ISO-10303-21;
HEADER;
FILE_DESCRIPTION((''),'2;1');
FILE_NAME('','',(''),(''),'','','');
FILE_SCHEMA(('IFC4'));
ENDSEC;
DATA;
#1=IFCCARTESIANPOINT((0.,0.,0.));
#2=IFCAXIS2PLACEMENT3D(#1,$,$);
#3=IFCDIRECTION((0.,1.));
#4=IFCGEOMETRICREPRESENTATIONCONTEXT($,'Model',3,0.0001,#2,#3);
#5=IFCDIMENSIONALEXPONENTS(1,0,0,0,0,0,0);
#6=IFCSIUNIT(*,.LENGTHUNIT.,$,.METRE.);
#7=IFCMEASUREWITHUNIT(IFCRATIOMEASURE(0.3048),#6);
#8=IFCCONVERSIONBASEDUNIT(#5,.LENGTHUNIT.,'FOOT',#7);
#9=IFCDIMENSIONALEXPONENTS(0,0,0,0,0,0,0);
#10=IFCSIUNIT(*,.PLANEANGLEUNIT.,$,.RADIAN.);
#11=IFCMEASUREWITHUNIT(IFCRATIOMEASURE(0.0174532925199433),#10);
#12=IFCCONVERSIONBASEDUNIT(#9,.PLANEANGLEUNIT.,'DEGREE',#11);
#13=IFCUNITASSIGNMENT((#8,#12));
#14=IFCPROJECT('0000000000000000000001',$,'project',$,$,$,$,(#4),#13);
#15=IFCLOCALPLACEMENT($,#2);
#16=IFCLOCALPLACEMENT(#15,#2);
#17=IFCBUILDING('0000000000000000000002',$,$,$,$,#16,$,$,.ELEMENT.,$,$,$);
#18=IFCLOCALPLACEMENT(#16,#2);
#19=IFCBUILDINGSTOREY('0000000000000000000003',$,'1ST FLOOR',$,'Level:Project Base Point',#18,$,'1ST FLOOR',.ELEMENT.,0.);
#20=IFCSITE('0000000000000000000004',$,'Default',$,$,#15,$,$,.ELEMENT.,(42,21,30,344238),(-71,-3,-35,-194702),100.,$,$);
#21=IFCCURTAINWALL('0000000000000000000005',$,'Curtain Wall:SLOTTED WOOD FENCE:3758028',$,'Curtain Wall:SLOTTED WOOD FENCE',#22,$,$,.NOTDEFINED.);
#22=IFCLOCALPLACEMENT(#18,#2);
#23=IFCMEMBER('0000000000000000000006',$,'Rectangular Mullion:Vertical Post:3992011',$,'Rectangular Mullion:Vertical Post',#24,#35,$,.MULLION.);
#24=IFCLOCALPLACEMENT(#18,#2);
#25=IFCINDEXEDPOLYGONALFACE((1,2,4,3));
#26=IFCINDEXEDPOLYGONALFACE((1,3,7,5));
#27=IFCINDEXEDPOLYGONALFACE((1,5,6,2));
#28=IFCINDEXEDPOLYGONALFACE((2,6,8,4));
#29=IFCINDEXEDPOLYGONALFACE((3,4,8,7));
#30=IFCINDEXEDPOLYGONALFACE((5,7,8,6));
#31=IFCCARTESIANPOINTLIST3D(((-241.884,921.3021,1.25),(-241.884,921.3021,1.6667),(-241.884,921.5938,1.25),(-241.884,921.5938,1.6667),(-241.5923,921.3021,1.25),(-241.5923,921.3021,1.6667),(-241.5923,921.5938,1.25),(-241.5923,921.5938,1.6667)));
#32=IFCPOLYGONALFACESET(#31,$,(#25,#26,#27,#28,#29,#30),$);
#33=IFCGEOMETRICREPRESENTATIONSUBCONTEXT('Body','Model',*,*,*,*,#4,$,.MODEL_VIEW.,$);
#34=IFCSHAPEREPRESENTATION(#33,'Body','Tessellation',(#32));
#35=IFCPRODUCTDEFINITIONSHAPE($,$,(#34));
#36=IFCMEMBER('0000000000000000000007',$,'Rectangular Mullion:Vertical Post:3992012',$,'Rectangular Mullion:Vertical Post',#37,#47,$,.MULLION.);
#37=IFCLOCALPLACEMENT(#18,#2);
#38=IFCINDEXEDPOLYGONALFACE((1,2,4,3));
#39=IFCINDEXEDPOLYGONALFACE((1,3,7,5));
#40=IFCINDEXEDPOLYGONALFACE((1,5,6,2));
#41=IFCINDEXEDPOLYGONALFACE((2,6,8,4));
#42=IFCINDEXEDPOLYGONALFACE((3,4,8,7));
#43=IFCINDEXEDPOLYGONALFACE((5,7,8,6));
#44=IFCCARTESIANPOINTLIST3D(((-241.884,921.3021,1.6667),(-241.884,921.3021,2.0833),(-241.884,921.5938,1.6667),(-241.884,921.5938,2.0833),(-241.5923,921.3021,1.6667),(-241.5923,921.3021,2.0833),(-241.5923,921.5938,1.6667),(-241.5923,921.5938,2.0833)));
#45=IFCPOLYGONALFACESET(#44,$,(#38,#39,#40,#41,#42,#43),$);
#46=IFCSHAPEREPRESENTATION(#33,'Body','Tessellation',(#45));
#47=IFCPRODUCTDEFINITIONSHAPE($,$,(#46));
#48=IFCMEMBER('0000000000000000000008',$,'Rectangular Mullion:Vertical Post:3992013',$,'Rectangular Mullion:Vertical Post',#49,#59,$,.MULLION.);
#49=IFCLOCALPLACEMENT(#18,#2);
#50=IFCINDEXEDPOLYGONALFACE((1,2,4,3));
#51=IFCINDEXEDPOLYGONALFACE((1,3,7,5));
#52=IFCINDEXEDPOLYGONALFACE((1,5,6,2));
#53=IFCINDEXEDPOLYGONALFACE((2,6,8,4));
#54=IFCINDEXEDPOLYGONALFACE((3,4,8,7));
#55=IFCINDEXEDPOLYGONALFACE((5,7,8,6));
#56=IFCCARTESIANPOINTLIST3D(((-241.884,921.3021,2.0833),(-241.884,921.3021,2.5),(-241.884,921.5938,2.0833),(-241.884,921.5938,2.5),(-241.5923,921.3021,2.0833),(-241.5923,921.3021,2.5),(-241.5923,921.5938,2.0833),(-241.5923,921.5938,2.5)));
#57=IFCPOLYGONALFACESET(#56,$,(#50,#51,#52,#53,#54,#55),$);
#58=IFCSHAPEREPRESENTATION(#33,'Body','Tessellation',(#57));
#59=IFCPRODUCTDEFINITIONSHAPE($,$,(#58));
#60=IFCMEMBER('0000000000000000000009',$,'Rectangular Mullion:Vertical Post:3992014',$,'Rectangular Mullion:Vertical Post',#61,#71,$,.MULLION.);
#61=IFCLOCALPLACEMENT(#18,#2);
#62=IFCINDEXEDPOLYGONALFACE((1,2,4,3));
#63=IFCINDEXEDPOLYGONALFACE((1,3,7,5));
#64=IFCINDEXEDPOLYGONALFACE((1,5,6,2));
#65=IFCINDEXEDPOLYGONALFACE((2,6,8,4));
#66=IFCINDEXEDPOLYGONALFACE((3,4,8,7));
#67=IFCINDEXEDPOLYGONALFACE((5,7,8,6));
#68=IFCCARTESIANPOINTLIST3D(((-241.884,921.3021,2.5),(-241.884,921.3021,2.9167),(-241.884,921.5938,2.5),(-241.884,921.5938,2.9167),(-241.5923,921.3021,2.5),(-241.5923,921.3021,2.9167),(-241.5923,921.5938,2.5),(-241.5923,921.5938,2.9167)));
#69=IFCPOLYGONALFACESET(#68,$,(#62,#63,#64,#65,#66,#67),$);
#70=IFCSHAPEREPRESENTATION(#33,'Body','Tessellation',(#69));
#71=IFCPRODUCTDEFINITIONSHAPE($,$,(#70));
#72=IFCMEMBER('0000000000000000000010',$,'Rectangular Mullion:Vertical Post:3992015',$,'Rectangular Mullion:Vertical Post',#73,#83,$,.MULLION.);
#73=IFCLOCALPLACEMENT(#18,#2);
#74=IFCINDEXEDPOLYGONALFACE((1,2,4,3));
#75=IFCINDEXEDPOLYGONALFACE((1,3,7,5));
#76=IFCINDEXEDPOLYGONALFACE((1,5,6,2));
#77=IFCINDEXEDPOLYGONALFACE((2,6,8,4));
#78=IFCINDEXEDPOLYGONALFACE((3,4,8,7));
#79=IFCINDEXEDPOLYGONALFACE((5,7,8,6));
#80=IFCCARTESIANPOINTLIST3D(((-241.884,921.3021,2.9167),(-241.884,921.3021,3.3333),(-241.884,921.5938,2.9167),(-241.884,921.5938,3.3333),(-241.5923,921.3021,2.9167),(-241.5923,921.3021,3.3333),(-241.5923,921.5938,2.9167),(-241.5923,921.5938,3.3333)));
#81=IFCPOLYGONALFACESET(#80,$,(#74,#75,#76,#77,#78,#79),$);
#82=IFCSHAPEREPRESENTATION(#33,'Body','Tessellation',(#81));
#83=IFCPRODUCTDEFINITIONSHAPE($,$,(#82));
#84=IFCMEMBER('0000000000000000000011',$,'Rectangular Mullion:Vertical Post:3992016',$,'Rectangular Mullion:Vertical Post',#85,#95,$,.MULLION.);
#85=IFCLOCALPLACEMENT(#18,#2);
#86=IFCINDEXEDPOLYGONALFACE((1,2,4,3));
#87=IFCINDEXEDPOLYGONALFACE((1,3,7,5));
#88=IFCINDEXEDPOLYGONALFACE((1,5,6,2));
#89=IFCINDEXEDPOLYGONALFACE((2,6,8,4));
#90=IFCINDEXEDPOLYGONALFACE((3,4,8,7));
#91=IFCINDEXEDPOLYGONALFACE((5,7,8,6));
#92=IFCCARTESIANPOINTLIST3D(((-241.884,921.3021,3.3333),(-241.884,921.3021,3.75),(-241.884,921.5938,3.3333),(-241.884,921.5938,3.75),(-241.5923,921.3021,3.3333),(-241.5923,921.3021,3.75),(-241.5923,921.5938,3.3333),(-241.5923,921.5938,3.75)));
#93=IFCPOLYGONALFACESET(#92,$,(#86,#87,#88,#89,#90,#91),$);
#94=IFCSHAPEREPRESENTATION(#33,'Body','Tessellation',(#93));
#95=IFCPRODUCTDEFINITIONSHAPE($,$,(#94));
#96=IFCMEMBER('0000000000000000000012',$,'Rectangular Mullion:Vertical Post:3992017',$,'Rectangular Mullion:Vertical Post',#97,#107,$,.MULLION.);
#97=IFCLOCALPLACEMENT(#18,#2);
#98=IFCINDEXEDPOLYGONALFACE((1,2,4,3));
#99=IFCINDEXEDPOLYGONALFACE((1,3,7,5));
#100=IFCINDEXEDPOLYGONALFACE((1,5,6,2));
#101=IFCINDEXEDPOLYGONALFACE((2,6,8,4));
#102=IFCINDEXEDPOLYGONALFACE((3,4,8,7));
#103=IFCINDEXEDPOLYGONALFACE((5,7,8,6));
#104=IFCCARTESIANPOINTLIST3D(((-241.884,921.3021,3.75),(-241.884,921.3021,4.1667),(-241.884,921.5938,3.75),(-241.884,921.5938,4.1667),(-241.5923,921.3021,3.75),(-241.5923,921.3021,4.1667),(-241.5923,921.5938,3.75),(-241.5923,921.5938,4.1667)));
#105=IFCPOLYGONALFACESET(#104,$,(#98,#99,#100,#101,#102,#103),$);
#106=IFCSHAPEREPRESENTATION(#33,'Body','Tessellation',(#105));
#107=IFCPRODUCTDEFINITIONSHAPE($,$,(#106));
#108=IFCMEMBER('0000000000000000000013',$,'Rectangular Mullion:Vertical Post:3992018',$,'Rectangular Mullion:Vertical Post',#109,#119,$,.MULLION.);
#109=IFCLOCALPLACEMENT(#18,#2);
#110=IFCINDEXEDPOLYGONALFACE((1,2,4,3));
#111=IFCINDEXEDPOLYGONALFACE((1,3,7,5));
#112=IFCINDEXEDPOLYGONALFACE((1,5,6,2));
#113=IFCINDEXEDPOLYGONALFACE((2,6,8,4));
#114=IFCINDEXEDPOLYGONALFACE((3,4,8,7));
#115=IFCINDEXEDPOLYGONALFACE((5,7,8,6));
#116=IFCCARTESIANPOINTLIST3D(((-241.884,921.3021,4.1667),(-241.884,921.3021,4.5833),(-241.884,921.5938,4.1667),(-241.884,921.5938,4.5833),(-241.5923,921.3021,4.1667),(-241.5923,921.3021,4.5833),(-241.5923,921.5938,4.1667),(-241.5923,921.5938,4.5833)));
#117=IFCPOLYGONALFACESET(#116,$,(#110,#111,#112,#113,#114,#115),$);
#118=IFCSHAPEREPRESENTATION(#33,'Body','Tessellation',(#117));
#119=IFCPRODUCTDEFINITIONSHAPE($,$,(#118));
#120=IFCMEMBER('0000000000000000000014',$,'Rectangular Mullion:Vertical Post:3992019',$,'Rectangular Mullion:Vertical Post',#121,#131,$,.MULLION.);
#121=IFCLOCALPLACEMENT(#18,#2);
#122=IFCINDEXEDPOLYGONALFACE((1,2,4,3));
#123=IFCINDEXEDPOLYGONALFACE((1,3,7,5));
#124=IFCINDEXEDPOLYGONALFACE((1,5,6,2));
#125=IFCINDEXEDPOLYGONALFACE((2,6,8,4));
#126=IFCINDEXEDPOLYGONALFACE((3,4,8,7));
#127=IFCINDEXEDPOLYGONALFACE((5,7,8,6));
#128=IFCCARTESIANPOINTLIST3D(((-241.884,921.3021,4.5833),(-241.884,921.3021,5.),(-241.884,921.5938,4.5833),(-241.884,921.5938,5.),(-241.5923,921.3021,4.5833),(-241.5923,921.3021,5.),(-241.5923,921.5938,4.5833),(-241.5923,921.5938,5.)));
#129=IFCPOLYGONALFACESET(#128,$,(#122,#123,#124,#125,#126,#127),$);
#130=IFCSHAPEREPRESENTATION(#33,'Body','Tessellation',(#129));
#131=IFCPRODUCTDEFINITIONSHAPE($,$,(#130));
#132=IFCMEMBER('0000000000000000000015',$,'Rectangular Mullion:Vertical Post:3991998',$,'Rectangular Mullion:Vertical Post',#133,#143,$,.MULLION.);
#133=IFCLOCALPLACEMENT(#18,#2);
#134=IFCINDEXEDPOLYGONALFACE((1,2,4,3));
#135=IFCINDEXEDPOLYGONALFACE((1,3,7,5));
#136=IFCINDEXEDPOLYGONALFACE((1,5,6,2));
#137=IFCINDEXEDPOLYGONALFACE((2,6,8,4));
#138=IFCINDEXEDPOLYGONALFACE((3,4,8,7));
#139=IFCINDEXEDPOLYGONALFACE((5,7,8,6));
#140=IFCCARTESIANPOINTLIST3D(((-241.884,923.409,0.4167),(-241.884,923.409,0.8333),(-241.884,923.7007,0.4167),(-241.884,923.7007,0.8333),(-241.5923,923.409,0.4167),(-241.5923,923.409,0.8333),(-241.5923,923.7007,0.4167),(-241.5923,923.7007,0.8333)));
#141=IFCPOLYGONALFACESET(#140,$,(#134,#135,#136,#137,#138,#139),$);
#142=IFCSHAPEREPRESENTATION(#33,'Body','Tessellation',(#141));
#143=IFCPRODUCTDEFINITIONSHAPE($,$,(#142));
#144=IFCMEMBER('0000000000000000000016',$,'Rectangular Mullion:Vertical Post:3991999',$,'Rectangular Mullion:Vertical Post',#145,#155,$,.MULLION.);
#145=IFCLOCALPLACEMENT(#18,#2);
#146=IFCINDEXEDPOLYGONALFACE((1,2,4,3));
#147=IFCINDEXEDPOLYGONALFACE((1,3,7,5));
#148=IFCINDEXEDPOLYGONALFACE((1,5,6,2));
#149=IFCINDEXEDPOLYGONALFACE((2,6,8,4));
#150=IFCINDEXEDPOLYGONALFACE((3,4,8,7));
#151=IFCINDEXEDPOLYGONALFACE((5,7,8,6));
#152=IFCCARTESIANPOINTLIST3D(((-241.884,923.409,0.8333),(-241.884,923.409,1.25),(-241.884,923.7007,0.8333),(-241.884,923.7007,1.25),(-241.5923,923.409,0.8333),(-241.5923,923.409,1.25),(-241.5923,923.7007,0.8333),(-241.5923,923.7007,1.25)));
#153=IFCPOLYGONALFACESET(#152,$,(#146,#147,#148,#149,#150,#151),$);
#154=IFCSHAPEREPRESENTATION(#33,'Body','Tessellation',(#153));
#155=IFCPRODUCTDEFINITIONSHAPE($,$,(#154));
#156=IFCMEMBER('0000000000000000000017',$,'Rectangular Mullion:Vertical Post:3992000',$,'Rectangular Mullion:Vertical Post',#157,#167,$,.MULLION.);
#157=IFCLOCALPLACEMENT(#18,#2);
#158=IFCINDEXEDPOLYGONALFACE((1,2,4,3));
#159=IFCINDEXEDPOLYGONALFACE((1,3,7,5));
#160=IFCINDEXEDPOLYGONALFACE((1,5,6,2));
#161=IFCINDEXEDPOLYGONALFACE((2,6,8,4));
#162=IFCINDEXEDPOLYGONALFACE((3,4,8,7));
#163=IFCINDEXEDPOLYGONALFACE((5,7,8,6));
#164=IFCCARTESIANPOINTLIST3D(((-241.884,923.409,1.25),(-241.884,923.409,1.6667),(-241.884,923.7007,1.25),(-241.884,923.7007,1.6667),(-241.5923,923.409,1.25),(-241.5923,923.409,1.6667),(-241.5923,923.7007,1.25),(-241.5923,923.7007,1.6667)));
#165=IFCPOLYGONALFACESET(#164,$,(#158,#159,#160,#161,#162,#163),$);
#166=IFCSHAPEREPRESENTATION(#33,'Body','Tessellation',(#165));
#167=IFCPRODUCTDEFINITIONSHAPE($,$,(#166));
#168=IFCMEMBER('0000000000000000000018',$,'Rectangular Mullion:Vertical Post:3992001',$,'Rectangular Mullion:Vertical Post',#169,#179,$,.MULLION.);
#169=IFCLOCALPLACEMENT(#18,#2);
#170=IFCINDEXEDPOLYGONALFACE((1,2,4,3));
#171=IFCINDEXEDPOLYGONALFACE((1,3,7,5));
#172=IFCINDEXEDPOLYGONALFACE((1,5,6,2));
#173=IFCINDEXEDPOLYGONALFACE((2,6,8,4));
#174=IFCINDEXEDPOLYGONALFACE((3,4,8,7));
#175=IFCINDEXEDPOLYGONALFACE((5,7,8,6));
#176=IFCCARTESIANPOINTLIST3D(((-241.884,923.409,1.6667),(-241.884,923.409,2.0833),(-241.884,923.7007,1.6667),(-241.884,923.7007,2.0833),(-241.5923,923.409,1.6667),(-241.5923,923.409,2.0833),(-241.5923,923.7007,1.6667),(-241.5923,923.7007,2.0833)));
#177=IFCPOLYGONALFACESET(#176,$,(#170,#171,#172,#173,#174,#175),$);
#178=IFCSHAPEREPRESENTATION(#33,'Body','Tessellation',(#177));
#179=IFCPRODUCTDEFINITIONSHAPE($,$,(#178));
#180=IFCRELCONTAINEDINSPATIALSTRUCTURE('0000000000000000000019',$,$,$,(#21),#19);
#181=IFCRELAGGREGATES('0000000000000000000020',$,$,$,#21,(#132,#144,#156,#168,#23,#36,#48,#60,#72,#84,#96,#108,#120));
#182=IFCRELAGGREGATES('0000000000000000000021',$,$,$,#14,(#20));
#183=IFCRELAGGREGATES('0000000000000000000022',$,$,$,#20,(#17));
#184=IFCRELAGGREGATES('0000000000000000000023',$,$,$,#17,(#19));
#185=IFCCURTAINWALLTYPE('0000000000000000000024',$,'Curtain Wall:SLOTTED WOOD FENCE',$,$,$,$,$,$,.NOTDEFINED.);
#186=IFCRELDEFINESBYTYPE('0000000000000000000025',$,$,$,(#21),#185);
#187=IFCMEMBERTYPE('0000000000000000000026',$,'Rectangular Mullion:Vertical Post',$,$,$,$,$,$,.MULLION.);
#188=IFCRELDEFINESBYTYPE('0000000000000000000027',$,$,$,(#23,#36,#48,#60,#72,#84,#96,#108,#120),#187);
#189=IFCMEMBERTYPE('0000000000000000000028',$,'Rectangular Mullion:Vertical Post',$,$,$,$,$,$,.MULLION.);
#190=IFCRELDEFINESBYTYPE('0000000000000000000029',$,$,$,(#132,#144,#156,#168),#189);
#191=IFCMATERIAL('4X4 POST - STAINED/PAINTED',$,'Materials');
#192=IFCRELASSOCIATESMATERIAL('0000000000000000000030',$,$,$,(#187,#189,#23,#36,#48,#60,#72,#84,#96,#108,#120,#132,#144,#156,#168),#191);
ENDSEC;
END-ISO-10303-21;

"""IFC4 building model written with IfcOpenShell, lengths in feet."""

from ifc_helpers import new_model, entity, si_unit, converted_unit, direction, frame, origin, origin_2d_with_axis, place, context, subcontext, project, spatial, rectangle, extrude, source, transform, mapped, material, material_profile, profile_set, profile_usage, type_object, type_shapes, element, aggregate, save


model = new_model("IFC4")

# Units and contexts
model_context = context("Model", 3, precision=0.0001, world=origin(), true_north=direction((0.0, 1.0)))
body_context = subcontext(model_context, "Body", "Model", "MODEL_VIEW")
ifc_project = project(units=[converted_unit("LENGTHUNIT", "FOOT", entity("IfcRatioMeasure", 0.3048), si_unit("LENGTHUNIT", "METRE"), dimensions=[1, 0, 0, 0, 0, 0, 0]), converted_unit("PLANEANGLEUNIT", "DEGREE", entity("IfcRatioMeasure", 0.0174532925199433), si_unit("PLANEANGLEUNIT", "RADIAN"), dimensions=[0, 0, 0, 0, 0, 0, 0])], contexts=[model_context])

# Site, building, storey
site_placement = place(None, origin())
site = spatial("IfcSite", under=ifc_project, at=site_placement, Name="Default", CompositionType="ELEMENT", RefLatitude=(42, 21, 30, 344238), RefLongitude=(-71, -3, -35, -194702), RefElevation=100.0)
building_placement = place(site_placement, origin())
building = spatial("IfcBuilding", under=site, at=building_placement, CompositionType="ELEMENT")
storey_placement = place(building_placement, origin())
storey = spatial("IfcBuildingStorey", under=building, at=storey_placement, Name="1ST FLOOR", ObjectType="Level:Project Base Point", LongName="1ST FLOOR", CompositionType="ELEMENT", Elevation=0.0)

# Curtain wall, members
curtain_wall_type = type_object("IfcCurtainWallType", Name="Curtain Wall:SLOTTED WOOD FENCE", PredefinedType="NOTDEFINED")
curtain_wall_placement = place(storey_placement, origin())
curtain_wall = element("IfcCurtainWall", 1, at=curtain_wall_placement, inside=storey, type_object=curtain_wall_type, Name="Curtain Wall:SLOTTED WOOD FENCE:3758028", ObjectType="Curtain Wall:SLOTTED WOOD FENCE", PredefinedType="NOTDEFINED")
ifc_material = material(Name="4X4 POST - STAINED/PAINTED", Category="Materials")
ifc_material_profile = material_profile(ifc_material, rectangle(XDim=0.2917, YDim=0.2917, at=origin_2d_with_axis()), Name="Vertical Post")
ifc_profile_set = profile_set([ifc_material_profile], Name="Vertical Post")
ifc_profile_usage_1 = profile_usage(ifc_profile_set)
member_type_1 = type_object("IfcMemberType", Name="Rectangular Mullion:Vertical Post", PredefinedType="MULLION", material=ifc_profile_set)
shared_shape_1 = source(origin(), body_context, "Body", "SweptSolid", [
    extrude(rectangle(XDim=0.2917, YDim=0.2917, at=origin_2d_with_axis()), frame((0.0, 0.2083, -0.4167), z_axis=(0.0, 0.0, 1.0), x_axis=(0.0, -1.0, 0.0)), (0.0, 0.0, 1.0), 0.4167),
])
type_shapes(member_type_1, [shared_shape_1])
member_1_placement = place(storey_placement, frame((-241.5298, 921.448, 1.25), z_axis=(0.0, 0.0, -1.0), x_axis=(0.0, -1.0, 0.0)))
member_1 = element("IfcMember", 2, at=member_1_placement, type_object=member_type_1, material=ifc_profile_usage_1, Name="Rectangular Mullion:Vertical Post:3992011", ObjectType="Rectangular Mullion:Vertical Post", PredefinedType="MULLION", context=body_context, shape_type="MappedRepresentation", body=[
    mapped(shared_shape_1, transform((0.0, 0.0, 0.0), scale=1.0)),
])
ifc_profile_usage_2 = profile_usage(ifc_profile_set)
member_2_placement = place(storey_placement, frame((-241.5298, 921.448, 1.6667), z_axis=(0.0, 0.0, -1.0), x_axis=(0.0, -1.0, 0.0)))
member_2 = element("IfcMember", 3, at=member_2_placement, type_object=member_type_1, material=ifc_profile_usage_2, Name="Rectangular Mullion:Vertical Post:3992012", ObjectType="Rectangular Mullion:Vertical Post", PredefinedType="MULLION", context=body_context, shape_type="MappedRepresentation", body=[
    mapped(shared_shape_1, transform((0.0, 0.0, 0.0), scale=1.0)),
])
ifc_profile_usage_3 = profile_usage(ifc_profile_set)
member_3_placement = place(storey_placement, frame((-241.5298, 921.448, 2.0833), z_axis=(0.0, 0.0, -1.0), x_axis=(0.0, -1.0, 0.0)))
member_3 = element("IfcMember", 4, at=member_3_placement, type_object=member_type_1, material=ifc_profile_usage_3, Name="Rectangular Mullion:Vertical Post:3992013", ObjectType="Rectangular Mullion:Vertical Post", PredefinedType="MULLION", context=body_context, shape_type="MappedRepresentation", body=[
    mapped(shared_shape_1, transform((0.0, 0.0, 0.0), scale=1.0)),
])
ifc_profile_usage_4 = profile_usage(ifc_profile_set)
member_4_placement = place(storey_placement, frame((-241.5298, 921.448, 2.5), z_axis=(0.0, 0.0, -1.0), x_axis=(0.0, -1.0, 0.0)))
member_4 = element("IfcMember", 5, at=member_4_placement, type_object=member_type_1, material=ifc_profile_usage_4, Name="Rectangular Mullion:Vertical Post:3992014", ObjectType="Rectangular Mullion:Vertical Post", PredefinedType="MULLION", context=body_context, shape_type="MappedRepresentation", body=[
    mapped(shared_shape_1, transform((0.0, 0.0, 0.0), scale=1.0)),
])
ifc_profile_usage_5 = profile_usage(ifc_profile_set)
member_5_placement = place(storey_placement, frame((-241.5298, 921.448, 2.9167), z_axis=(0.0, 0.0, -1.0), x_axis=(0.0, -1.0, 0.0)))
member_5 = element("IfcMember", 6, at=member_5_placement, type_object=member_type_1, material=ifc_profile_usage_5, Name="Rectangular Mullion:Vertical Post:3992015", ObjectType="Rectangular Mullion:Vertical Post", PredefinedType="MULLION", context=body_context, shape_type="MappedRepresentation", body=[
    mapped(shared_shape_1, transform((0.0, 0.0, 0.0), scale=1.0)),
])
ifc_profile_usage_6 = profile_usage(ifc_profile_set)
member_6_placement = place(storey_placement, frame((-241.5298, 921.448, 3.3333), z_axis=(0.0, 0.0, -1.0), x_axis=(0.0, -1.0, 0.0)))
member_6 = element("IfcMember", 7, at=member_6_placement, type_object=member_type_1, material=ifc_profile_usage_6, Name="Rectangular Mullion:Vertical Post:3992016", ObjectType="Rectangular Mullion:Vertical Post", PredefinedType="MULLION", context=body_context, shape_type="MappedRepresentation", body=[
    mapped(shared_shape_1, transform((0.0, 0.0, 0.0), scale=1.0)),
])
ifc_profile_usage_7 = profile_usage(ifc_profile_set)
member_7_placement = place(storey_placement, frame((-241.5298, 921.448, 3.75), z_axis=(0.0, 0.0, -1.0), x_axis=(0.0, -1.0, 0.0)))
member_7 = element("IfcMember", 8, at=member_7_placement, type_object=member_type_1, material=ifc_profile_usage_7, Name="Rectangular Mullion:Vertical Post:3992017", ObjectType="Rectangular Mullion:Vertical Post", PredefinedType="MULLION", context=body_context, shape_type="MappedRepresentation", body=[
    mapped(shared_shape_1, transform((0.0, 0.0, 0.0), scale=1.0)),
])
ifc_profile_usage_8 = profile_usage(ifc_profile_set)
member_8_placement = place(storey_placement, frame((-241.5298, 921.448, 4.1667), z_axis=(0.0, 0.0, -1.0), x_axis=(0.0, -1.0, 0.0)))
member_8 = element("IfcMember", 9, at=member_8_placement, type_object=member_type_1, material=ifc_profile_usage_8, Name="Rectangular Mullion:Vertical Post:3992018", ObjectType="Rectangular Mullion:Vertical Post", PredefinedType="MULLION", context=body_context, shape_type="MappedRepresentation", body=[
    mapped(shared_shape_1, transform((0.0, 0.0, 0.0), scale=1.0)),
])
ifc_profile_usage_9 = profile_usage(ifc_profile_set)
member_9_placement = place(storey_placement, frame((-241.5298, 921.448, 4.5833), z_axis=(0.0, 0.0, -1.0), x_axis=(0.0, -1.0, 0.0)))
member_9 = element("IfcMember", 10, at=member_9_placement, type_object=member_type_1, material=ifc_profile_usage_9, Name="Rectangular Mullion:Vertical Post:3992019", ObjectType="Rectangular Mullion:Vertical Post", PredefinedType="MULLION", context=body_context, shape_type="MappedRepresentation", body=[
    mapped(shared_shape_1, transform((0.0, 0.0, 0.0), scale=1.0)),
])
ifc_profile_usage_10 = profile_usage(ifc_profile_set)
member_type_2 = type_object("IfcMemberType", Name="Rectangular Mullion:Vertical Post", PredefinedType="MULLION", material=ifc_profile_set)
shared_shape_2 = source(origin(), body_context, "Body", "SweptSolid", [
    extrude(rectangle(XDim=0.2917, YDim=0.2917, at=origin_2d_with_axis()), frame((-0.1458, 0.2083, -0.4167), z_axis=(0.0, 0.0, 1.0), x_axis=(0.0, -1.0, 0.0)), (0.0, 0.0, 1.0), 0.4167),
])
type_shapes(member_type_2, [shared_shape_2])
member_10_placement = place(storey_placement, frame((-241.5298, 923.7007, 0.8333), z_axis=(0.0, 0.0, 1.0), x_axis=(0.0, 1.0, 0.0)))
member_10 = element("IfcMember", 11, at=member_10_placement, type_object=member_type_2, material=ifc_profile_usage_10, Name="Rectangular Mullion:Vertical Post:3991998", ObjectType="Rectangular Mullion:Vertical Post", PredefinedType="MULLION", context=body_context, shape_type="MappedRepresentation", body=[
    mapped(shared_shape_2, transform((0.0, 0.0, 0.0), scale=1.0)),
])
ifc_profile_usage_11 = profile_usage(ifc_profile_set)
member_11_placement = place(storey_placement, frame((-241.5298, 923.7007, 1.25), z_axis=(0.0, 0.0, 1.0), x_axis=(0.0, 1.0, 0.0)))
member_11 = element("IfcMember", 12, at=member_11_placement, type_object=member_type_2, material=ifc_profile_usage_11, Name="Rectangular Mullion:Vertical Post:3991999", ObjectType="Rectangular Mullion:Vertical Post", PredefinedType="MULLION", context=body_context, shape_type="MappedRepresentation", body=[
    mapped(shared_shape_2, transform((0.0, 0.0, 0.0), scale=1.0)),
])
ifc_profile_usage_12 = profile_usage(ifc_profile_set)
member_12_placement = place(storey_placement, frame((-241.5298, 923.7007, 1.6667), z_axis=(0.0, 0.0, 1.0), x_axis=(0.0, 1.0, 0.0)))
member_12 = element("IfcMember", 13, at=member_12_placement, type_object=member_type_2, material=ifc_profile_usage_12, Name="Rectangular Mullion:Vertical Post:3992000", ObjectType="Rectangular Mullion:Vertical Post", PredefinedType="MULLION", context=body_context, shape_type="MappedRepresentation", body=[
    mapped(shared_shape_2, transform((0.0, 0.0, 0.0), scale=1.0)),
])
ifc_profile_usage_13 = profile_usage(ifc_profile_set)
member_13_placement = place(storey_placement, frame((-241.5298, 923.7007, 2.0833), z_axis=(0.0, 0.0, 1.0), x_axis=(0.0, 1.0, 0.0)))
member_13 = element("IfcMember", 14, at=member_13_placement, type_object=member_type_2, material=ifc_profile_usage_13, Name="Rectangular Mullion:Vertical Post:3992001", ObjectType="Rectangular Mullion:Vertical Post", PredefinedType="MULLION", context=body_context, shape_type="MappedRepresentation", body=[
    mapped(shared_shape_2, transform((0.0, 0.0, 0.0), scale=1.0)),
])
aggregate(curtain_wall, [member_10, member_11, member_12, member_13, member_1, member_2, member_3, member_4, member_5, member_6, member_7, member_8, member_9])

save(model, "model.ifc")
